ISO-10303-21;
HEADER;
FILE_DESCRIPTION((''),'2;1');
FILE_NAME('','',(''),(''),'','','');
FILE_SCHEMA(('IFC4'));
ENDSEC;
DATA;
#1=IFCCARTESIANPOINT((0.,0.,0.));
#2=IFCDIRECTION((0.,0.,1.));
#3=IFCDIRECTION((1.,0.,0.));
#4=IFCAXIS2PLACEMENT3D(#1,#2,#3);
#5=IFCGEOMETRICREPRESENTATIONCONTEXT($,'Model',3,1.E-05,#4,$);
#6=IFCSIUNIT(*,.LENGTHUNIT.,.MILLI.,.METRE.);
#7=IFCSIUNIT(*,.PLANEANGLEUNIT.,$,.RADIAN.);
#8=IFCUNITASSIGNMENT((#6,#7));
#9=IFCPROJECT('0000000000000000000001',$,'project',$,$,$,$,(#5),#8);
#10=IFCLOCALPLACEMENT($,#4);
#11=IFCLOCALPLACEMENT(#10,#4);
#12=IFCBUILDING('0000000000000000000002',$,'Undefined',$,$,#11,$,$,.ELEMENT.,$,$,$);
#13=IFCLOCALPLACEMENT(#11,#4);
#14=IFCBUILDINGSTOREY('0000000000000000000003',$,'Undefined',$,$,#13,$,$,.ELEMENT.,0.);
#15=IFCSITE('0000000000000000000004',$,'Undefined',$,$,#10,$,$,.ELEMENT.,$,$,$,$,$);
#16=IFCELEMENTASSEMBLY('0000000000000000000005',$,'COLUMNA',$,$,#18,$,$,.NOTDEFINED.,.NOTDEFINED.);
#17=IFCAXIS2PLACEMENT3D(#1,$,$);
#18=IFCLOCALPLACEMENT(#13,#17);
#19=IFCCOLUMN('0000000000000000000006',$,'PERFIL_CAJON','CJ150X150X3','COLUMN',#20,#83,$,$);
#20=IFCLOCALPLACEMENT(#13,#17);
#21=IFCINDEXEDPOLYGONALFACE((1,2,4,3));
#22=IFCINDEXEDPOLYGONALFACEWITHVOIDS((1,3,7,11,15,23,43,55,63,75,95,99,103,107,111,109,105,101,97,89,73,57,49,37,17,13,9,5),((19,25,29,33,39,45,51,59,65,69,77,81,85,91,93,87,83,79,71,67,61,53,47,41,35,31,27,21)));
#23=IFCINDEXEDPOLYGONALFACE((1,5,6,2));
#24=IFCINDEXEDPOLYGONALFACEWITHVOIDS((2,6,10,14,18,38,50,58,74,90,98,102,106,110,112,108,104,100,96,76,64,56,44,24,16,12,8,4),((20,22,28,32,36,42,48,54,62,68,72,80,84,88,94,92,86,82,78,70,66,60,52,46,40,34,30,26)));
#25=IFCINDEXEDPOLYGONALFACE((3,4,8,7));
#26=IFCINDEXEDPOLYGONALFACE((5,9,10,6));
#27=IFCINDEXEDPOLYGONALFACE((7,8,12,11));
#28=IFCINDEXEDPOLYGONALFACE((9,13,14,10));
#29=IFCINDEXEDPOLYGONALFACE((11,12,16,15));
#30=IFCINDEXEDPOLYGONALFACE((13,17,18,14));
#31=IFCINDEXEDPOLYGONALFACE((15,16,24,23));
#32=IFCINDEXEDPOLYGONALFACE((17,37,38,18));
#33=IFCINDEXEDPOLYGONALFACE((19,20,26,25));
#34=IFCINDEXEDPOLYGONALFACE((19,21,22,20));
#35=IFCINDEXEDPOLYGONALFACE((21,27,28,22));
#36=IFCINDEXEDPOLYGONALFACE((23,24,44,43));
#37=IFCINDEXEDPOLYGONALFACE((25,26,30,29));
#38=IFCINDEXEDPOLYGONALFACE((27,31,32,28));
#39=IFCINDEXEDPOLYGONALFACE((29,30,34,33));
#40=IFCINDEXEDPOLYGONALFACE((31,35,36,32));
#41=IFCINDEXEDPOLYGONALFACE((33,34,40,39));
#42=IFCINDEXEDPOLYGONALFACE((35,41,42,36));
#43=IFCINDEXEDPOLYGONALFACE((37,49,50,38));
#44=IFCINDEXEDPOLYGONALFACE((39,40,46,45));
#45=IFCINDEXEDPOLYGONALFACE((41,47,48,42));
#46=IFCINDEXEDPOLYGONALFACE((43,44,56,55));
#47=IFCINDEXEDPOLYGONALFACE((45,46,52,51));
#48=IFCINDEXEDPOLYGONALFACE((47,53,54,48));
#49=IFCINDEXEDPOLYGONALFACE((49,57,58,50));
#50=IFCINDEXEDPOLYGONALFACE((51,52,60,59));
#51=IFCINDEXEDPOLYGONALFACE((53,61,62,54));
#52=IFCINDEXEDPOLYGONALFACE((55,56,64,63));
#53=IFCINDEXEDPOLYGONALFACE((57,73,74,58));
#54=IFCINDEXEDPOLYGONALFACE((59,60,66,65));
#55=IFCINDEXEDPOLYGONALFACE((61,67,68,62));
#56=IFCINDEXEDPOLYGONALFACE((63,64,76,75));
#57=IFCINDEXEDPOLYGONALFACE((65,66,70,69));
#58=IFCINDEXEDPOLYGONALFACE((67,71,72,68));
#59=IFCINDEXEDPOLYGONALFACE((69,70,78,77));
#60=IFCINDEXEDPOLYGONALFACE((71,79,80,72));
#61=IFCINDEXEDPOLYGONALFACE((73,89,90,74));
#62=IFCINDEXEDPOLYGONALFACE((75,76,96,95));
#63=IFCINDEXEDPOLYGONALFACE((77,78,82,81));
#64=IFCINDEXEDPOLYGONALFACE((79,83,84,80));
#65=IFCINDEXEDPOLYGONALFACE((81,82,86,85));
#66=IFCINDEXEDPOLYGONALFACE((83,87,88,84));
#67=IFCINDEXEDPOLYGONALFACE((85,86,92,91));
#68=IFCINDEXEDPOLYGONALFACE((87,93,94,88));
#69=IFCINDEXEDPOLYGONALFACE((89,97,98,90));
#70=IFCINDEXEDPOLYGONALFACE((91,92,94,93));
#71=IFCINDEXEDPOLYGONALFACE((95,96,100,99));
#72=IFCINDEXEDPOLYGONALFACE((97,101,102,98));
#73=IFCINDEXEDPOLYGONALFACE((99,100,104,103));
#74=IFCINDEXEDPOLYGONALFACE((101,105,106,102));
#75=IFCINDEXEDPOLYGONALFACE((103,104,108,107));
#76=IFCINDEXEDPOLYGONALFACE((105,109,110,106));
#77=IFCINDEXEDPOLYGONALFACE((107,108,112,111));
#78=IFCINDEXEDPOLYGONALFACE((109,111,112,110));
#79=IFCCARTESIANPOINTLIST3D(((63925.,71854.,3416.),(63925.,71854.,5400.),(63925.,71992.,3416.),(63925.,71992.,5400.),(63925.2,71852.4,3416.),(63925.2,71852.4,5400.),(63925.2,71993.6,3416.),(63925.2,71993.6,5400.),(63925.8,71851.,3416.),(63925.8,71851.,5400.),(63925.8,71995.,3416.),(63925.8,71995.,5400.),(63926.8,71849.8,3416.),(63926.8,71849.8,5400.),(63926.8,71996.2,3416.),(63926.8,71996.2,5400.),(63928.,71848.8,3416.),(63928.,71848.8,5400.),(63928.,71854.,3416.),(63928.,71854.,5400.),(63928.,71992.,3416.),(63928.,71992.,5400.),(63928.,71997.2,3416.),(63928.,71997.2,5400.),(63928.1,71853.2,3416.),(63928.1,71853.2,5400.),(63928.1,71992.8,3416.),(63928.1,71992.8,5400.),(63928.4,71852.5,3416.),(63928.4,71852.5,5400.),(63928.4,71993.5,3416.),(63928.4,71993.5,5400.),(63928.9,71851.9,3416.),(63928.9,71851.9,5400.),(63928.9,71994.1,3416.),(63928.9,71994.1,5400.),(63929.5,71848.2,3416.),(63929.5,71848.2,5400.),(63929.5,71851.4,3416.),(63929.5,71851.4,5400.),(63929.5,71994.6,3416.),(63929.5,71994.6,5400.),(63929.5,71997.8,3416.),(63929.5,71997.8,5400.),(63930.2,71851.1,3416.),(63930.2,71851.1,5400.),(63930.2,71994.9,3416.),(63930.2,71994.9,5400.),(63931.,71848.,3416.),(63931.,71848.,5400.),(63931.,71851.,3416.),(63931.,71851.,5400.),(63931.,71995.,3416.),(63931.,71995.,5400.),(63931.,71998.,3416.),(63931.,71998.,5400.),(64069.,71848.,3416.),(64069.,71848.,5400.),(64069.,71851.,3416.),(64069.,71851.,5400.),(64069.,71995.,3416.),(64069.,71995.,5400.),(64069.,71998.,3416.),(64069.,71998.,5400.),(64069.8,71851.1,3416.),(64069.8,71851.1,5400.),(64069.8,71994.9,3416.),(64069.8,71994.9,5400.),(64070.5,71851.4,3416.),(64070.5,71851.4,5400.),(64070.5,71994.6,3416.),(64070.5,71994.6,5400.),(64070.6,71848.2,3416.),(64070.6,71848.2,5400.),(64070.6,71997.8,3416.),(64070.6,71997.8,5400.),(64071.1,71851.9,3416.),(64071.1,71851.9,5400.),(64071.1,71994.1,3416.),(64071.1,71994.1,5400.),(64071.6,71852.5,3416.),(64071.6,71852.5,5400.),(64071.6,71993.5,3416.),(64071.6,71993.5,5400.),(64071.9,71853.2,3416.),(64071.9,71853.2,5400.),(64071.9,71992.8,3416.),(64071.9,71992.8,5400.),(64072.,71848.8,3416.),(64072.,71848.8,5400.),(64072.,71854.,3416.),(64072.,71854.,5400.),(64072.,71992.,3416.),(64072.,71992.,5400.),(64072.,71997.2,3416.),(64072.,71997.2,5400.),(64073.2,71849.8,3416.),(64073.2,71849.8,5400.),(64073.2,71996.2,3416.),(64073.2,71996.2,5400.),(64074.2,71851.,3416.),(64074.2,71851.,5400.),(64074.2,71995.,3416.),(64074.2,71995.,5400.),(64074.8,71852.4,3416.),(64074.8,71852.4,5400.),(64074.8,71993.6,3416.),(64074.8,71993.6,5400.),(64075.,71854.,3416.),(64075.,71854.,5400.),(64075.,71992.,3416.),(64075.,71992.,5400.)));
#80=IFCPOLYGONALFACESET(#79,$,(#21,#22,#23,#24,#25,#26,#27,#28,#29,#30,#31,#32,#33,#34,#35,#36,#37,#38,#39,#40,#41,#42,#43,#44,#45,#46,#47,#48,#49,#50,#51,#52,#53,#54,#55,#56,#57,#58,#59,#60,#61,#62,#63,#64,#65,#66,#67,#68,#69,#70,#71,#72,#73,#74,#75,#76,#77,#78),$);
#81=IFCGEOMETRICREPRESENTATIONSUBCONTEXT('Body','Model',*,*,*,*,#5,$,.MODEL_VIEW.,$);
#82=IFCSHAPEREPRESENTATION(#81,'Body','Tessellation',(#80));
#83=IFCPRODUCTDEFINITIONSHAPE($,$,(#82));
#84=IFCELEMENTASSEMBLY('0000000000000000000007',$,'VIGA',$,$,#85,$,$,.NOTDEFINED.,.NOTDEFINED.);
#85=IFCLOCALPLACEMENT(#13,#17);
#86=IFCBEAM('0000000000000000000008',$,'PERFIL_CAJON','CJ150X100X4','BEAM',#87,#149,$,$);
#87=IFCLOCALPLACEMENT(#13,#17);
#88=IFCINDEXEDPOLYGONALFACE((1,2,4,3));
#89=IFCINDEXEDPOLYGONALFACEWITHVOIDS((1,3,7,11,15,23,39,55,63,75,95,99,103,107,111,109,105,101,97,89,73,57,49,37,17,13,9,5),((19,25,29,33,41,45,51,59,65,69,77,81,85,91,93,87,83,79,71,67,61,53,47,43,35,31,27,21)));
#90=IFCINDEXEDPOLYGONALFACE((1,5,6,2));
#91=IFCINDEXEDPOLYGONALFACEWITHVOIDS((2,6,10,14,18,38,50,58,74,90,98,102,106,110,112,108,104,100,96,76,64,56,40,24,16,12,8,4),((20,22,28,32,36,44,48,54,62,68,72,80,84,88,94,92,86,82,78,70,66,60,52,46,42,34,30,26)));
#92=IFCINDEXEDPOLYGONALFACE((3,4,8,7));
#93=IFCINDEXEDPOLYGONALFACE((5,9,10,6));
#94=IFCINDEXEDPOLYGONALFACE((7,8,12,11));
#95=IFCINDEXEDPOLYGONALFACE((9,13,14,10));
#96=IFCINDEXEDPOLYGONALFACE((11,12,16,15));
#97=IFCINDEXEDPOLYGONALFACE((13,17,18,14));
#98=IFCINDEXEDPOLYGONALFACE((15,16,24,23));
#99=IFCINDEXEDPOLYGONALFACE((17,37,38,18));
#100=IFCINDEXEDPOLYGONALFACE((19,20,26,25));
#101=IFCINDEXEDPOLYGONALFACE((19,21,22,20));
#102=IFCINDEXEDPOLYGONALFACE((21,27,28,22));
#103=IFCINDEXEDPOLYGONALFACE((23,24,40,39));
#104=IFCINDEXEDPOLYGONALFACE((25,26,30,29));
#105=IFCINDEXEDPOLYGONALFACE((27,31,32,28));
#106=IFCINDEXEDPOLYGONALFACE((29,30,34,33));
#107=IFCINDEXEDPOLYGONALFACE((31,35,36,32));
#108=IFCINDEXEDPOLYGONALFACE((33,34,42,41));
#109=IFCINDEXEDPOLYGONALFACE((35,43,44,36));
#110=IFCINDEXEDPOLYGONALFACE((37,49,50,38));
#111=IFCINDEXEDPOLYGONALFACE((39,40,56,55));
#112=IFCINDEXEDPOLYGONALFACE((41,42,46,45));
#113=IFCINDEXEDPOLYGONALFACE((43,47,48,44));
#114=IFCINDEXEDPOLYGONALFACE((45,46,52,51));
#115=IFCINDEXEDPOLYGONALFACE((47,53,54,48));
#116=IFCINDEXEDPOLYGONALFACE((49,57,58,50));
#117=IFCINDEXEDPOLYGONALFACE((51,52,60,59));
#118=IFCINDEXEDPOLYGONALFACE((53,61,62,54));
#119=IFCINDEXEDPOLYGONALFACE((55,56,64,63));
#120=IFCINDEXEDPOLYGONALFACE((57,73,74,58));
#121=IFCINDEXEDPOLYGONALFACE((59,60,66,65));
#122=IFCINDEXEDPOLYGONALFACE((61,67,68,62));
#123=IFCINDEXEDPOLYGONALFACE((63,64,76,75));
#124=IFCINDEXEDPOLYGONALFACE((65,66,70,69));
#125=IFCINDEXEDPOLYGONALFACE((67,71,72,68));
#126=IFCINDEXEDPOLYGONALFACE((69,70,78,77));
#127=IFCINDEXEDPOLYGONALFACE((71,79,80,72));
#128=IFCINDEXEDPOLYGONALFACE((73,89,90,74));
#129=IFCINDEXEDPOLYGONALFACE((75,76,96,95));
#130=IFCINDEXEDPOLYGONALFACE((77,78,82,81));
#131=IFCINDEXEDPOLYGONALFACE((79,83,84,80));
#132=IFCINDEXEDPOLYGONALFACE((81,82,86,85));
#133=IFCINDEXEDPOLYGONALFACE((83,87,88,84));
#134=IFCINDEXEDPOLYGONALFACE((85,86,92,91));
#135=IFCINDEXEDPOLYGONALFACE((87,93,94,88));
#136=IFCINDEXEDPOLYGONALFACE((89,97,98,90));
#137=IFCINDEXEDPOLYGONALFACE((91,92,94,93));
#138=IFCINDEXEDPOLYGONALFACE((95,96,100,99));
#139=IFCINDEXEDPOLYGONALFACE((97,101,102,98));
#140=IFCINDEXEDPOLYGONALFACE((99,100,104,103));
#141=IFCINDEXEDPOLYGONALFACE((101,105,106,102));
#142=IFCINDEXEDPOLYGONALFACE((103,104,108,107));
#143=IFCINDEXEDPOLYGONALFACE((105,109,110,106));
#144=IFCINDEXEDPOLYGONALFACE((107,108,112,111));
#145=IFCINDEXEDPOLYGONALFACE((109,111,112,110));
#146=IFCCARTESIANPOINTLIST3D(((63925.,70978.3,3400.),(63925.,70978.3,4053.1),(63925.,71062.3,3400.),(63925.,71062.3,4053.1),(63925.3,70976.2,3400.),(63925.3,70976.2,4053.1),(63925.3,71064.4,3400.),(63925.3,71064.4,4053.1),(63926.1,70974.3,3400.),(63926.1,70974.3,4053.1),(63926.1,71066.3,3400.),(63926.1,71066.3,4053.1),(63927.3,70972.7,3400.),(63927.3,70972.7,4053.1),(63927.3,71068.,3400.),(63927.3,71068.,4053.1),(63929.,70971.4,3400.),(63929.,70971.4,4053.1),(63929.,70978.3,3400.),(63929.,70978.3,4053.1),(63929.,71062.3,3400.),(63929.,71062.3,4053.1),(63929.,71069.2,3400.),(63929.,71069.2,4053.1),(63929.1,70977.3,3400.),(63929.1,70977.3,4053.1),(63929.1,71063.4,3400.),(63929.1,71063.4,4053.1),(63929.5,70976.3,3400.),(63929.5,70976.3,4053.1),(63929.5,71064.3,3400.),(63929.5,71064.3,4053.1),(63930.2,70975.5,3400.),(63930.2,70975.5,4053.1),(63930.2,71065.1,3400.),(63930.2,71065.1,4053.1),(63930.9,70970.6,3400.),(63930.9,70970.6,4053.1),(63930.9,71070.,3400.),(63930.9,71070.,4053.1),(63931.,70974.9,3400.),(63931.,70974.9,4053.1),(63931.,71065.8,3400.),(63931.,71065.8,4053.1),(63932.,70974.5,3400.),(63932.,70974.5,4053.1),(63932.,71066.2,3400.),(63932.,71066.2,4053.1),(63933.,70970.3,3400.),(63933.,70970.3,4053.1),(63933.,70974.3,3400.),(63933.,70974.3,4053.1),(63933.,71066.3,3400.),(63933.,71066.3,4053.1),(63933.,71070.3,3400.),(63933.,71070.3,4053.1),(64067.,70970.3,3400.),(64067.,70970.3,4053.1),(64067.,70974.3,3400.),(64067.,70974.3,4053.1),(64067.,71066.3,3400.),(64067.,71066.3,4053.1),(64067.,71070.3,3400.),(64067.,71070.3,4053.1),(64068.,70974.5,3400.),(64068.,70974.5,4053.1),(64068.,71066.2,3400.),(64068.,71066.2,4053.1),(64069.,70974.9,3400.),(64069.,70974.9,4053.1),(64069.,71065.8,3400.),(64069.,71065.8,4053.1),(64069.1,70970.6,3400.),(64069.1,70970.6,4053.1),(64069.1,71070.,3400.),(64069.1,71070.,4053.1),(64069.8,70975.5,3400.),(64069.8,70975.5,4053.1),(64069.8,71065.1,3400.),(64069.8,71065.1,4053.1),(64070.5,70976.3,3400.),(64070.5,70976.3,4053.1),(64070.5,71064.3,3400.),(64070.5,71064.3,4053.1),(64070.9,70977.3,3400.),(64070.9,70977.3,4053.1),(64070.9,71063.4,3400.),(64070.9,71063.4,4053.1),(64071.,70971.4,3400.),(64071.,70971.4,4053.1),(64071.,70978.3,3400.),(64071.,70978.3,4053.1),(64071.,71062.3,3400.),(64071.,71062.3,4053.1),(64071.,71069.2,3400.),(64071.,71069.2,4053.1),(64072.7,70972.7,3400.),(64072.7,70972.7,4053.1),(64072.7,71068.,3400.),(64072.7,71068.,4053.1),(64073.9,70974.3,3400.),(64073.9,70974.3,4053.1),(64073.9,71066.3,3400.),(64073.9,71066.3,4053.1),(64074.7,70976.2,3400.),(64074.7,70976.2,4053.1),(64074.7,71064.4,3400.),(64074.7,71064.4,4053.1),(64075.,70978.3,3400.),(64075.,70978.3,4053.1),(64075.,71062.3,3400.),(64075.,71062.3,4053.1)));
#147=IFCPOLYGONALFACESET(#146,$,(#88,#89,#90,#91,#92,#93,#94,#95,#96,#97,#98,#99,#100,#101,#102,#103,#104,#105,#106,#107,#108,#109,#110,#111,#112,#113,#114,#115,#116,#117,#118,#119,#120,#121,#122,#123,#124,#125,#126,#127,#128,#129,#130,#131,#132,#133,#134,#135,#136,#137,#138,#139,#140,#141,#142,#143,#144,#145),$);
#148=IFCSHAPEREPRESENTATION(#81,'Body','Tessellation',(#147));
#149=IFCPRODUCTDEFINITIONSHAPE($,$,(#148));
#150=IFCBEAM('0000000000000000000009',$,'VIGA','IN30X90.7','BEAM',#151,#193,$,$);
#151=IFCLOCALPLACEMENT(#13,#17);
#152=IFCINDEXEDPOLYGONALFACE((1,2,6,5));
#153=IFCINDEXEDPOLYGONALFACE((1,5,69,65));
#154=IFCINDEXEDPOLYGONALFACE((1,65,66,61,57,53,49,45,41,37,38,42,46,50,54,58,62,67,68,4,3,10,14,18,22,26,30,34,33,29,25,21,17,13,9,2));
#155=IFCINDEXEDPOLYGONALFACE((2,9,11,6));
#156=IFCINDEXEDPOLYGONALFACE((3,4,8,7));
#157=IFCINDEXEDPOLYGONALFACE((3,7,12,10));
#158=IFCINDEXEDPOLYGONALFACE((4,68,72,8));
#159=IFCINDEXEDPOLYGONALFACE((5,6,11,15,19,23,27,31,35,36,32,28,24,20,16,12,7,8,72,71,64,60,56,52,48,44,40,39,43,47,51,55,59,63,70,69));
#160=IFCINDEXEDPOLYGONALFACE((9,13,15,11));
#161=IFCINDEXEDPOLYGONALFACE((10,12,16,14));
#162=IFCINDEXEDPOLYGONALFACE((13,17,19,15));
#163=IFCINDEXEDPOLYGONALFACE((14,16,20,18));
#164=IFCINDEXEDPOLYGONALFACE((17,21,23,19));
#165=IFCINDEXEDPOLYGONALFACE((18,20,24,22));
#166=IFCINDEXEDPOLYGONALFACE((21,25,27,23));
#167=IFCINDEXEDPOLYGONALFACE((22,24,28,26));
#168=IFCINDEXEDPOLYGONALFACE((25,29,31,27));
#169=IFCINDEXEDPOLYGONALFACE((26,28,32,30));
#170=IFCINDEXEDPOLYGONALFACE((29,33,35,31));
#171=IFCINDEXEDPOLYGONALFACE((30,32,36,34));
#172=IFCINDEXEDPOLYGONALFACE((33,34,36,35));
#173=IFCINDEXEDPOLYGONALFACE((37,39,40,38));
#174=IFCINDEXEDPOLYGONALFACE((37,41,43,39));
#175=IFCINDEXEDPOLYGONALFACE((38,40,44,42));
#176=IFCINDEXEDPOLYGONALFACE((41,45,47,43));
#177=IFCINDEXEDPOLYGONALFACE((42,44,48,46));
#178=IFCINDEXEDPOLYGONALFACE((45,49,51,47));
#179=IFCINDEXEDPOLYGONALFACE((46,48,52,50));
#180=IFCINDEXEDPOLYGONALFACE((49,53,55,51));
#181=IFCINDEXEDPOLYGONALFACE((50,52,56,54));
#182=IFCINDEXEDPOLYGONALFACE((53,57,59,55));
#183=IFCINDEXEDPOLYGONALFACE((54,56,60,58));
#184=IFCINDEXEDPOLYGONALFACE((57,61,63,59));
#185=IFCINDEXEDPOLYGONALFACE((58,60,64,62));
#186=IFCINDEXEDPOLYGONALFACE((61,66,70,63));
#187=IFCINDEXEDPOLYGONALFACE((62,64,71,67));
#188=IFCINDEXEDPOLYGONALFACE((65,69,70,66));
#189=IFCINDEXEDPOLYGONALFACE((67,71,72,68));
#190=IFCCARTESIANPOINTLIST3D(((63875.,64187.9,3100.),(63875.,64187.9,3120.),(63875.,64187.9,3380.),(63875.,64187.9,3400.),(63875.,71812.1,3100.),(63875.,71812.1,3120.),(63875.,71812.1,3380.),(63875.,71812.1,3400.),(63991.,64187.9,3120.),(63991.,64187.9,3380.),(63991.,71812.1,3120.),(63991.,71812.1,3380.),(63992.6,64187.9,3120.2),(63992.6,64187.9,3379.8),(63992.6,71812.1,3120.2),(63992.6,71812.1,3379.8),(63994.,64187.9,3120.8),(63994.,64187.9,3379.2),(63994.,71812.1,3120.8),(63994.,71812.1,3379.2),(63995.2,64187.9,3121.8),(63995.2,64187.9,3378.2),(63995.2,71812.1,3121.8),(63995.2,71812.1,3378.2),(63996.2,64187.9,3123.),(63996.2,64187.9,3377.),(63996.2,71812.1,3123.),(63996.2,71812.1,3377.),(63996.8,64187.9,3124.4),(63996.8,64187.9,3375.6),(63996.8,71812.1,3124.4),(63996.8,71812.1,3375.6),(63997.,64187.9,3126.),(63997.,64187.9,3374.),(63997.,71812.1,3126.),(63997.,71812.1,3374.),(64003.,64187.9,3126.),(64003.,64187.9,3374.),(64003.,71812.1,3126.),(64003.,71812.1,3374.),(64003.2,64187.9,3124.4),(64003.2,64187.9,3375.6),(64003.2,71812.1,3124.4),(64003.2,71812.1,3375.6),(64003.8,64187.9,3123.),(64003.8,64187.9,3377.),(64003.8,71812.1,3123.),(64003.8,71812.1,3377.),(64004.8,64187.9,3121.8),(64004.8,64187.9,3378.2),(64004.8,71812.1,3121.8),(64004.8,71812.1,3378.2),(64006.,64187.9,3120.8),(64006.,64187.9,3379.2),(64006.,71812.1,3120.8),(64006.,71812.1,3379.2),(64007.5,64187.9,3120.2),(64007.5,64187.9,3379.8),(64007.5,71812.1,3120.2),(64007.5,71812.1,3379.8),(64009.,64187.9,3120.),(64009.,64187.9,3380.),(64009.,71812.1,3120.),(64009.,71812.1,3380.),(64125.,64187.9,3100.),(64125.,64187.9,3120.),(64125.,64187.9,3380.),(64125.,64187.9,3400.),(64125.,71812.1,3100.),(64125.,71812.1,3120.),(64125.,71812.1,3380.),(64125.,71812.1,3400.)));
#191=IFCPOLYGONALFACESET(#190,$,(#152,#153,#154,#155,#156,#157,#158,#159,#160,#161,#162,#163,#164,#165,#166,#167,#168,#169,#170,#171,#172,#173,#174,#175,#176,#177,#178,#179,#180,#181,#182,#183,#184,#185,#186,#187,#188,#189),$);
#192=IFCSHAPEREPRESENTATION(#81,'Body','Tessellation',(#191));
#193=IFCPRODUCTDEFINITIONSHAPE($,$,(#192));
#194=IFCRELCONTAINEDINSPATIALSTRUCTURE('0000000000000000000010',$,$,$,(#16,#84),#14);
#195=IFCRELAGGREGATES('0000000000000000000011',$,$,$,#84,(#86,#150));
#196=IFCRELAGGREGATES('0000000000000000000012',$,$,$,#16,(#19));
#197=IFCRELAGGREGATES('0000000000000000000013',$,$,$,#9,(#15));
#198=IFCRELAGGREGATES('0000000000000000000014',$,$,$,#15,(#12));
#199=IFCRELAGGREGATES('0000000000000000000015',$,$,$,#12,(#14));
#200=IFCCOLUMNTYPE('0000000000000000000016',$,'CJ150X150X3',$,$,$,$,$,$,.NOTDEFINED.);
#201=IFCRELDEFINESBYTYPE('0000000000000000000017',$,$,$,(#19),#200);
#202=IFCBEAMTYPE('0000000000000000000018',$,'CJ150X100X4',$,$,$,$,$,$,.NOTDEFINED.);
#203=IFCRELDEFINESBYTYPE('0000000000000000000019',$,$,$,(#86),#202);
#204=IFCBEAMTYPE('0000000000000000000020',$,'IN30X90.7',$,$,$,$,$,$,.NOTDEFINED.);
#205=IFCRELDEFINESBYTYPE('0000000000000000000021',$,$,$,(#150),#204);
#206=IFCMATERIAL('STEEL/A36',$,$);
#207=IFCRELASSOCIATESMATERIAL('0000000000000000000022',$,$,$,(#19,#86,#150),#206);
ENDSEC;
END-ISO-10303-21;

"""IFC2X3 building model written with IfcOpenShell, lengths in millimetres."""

from ifc_helpers import new_model, si_unit, frame, origin_with_axes, origin_2d_with_axis, place, context, subcontext, project, spatial, hollow_rectangle, i_section, extrude, material, type_object, element, aggregate, save


model = new_model("IFC2X3")

# Units and contexts
model_context = context("Model", 3, precision=1e-05, world=origin_with_axes())
body_context = subcontext(model_context, "Body", "Model", "MODEL_VIEW")
ifc_project = project(units=[si_unit("LENGTHUNIT", "METRE", prefix="MILLI"), si_unit("PLANEANGLEUNIT", "RADIAN")], contexts=[model_context])

# Site, building, storey
site_placement = place(None, origin_with_axes())
site = spatial("IfcSite", under=ifc_project, at=site_placement, Name="Undefined", CompositionType="ELEMENT")
building_placement = place(site_placement, origin_with_axes())
building = spatial("IfcBuilding", under=site, at=building_placement, Name="Undefined", CompositionType="ELEMENT")
storey_placement = place(building_placement, origin_with_axes())
storey = spatial("IfcBuildingStorey", under=building, at=storey_placement, Name="Undefined", CompositionType="ELEMENT", Elevation=0.0)

# Element assembly, column
assembly_1_placement = place(storey_placement, origin_with_axes())
assembly_1 = element("IfcElementAssembly", 1, at=assembly_1_placement, inside=storey, Name="COLUMNA", AssemblyPlace="NOTDEFINED", PredefinedType="NOTDEFINED")
ifc_material_1 = material(Name="STEEL/A36")
column_type = type_object("IfcColumnType", Name="CJ150X150X3", PredefinedType="NOTDEFINED")
column_placement = place(assembly_1_placement, frame((64000.0, 71923.0, 3416.0), z_axis=(0.0, 0.0, 1.0), x_axis=(-1.0, 0.0, 0.0)))
column = element("IfcColumn", 2, at=column_placement, type_object=column_type, material=ifc_material_1, Name="PERFIL_CAJON", Description="CJ150X150X3", ObjectType="COLUMN", context=body_context, shape_type="SweptSolid", body=[
    extrude(hollow_rectangle(XDim=150.0, YDim=150.0, WallThickness=3.0, InnerFilletRadius=3.0, OuterFilletRadius=6.0, at=origin_2d_with_axis()), frame((0.0, 0.0, 1984.0), z_axis=(0.0, 0.0, -1.0), x_axis=(0.0, 1.0, 0.0)), (0.0, 0.0, 1.0), 1984.0),
])

# Element assembly, beams
assembly_2_placement = place(storey_placement, origin_with_axes())
assembly_2 = element("IfcElementAssembly", 3, at=assembly_2_placement, inside=storey, Name="VIGA", AssemblyPlace="NOTDEFINED", PredefinedType="NOTDEFINED")
beam_type_1 = type_object("IfcBeamType", Name="CJ150X100X4", PredefinedType="NOTDEFINED")
beam_1_placement = place(assembly_2_placement, frame((64000.0, 71020.3, 4053.1), z_axis=(-1.0, 0.0, 0.0), x_axis=(0.0, 0.0, -1.0)))
beam_1 = element("IfcBeam", 4, at=beam_1_placement, type_object=beam_type_1, material=ifc_material_1, Name="PERFIL_CAJON", Description="CJ150X100X4", ObjectType="BEAM", context=body_context, shape_type="SweptSolid", body=[
    extrude(hollow_rectangle(XDim=100.0, YDim=150.0, WallThickness=4.0, InnerFilletRadius=4.0, OuterFilletRadius=8.0, at=origin_2d_with_axis()), frame((653.1, 0.0, 0.0), z_axis=(-1.0, 0.0, 0.0), x_axis=(0.0, -1.0, 0.0)), (0.0, 0.0, 1.0), 653.1),
])
beam_type_2 = type_object("IfcBeamType", Name="IN30X90.7", PredefinedType="NOTDEFINED")
beam_2_placement = place(assembly_2_placement, frame((64000.0, 71812.1, 3250.0), z_axis=(0.0, 0.0, 1.0), x_axis=(0.0, -1.0, 0.0)))
beam_2 = element("IfcBeam", 5, at=beam_2_placement, type_object=beam_type_2, material=ifc_material_1, Name="VIGA", Description="IN30X90.7", ObjectType="BEAM", context=body_context, shape_type="SweptSolid", body=[
    extrude(i_section(OverallWidth=250.0, OverallDepth=300.0, WebThickness=6.0, FlangeThickness=20.0, FilletRadius=6.0, at=origin_2d_with_axis()), frame((7624.2, 0.0, 0.0), z_axis=(-1.0, 0.0, 0.0), x_axis=(0.0, -1.0, 0.0)), (0.0, 0.0, 1.0), 7624.2),
])

aggregate(assembly_2, [beam_1, beam_2])

aggregate(assembly_1, [column])

save(model, "model.ifc")
